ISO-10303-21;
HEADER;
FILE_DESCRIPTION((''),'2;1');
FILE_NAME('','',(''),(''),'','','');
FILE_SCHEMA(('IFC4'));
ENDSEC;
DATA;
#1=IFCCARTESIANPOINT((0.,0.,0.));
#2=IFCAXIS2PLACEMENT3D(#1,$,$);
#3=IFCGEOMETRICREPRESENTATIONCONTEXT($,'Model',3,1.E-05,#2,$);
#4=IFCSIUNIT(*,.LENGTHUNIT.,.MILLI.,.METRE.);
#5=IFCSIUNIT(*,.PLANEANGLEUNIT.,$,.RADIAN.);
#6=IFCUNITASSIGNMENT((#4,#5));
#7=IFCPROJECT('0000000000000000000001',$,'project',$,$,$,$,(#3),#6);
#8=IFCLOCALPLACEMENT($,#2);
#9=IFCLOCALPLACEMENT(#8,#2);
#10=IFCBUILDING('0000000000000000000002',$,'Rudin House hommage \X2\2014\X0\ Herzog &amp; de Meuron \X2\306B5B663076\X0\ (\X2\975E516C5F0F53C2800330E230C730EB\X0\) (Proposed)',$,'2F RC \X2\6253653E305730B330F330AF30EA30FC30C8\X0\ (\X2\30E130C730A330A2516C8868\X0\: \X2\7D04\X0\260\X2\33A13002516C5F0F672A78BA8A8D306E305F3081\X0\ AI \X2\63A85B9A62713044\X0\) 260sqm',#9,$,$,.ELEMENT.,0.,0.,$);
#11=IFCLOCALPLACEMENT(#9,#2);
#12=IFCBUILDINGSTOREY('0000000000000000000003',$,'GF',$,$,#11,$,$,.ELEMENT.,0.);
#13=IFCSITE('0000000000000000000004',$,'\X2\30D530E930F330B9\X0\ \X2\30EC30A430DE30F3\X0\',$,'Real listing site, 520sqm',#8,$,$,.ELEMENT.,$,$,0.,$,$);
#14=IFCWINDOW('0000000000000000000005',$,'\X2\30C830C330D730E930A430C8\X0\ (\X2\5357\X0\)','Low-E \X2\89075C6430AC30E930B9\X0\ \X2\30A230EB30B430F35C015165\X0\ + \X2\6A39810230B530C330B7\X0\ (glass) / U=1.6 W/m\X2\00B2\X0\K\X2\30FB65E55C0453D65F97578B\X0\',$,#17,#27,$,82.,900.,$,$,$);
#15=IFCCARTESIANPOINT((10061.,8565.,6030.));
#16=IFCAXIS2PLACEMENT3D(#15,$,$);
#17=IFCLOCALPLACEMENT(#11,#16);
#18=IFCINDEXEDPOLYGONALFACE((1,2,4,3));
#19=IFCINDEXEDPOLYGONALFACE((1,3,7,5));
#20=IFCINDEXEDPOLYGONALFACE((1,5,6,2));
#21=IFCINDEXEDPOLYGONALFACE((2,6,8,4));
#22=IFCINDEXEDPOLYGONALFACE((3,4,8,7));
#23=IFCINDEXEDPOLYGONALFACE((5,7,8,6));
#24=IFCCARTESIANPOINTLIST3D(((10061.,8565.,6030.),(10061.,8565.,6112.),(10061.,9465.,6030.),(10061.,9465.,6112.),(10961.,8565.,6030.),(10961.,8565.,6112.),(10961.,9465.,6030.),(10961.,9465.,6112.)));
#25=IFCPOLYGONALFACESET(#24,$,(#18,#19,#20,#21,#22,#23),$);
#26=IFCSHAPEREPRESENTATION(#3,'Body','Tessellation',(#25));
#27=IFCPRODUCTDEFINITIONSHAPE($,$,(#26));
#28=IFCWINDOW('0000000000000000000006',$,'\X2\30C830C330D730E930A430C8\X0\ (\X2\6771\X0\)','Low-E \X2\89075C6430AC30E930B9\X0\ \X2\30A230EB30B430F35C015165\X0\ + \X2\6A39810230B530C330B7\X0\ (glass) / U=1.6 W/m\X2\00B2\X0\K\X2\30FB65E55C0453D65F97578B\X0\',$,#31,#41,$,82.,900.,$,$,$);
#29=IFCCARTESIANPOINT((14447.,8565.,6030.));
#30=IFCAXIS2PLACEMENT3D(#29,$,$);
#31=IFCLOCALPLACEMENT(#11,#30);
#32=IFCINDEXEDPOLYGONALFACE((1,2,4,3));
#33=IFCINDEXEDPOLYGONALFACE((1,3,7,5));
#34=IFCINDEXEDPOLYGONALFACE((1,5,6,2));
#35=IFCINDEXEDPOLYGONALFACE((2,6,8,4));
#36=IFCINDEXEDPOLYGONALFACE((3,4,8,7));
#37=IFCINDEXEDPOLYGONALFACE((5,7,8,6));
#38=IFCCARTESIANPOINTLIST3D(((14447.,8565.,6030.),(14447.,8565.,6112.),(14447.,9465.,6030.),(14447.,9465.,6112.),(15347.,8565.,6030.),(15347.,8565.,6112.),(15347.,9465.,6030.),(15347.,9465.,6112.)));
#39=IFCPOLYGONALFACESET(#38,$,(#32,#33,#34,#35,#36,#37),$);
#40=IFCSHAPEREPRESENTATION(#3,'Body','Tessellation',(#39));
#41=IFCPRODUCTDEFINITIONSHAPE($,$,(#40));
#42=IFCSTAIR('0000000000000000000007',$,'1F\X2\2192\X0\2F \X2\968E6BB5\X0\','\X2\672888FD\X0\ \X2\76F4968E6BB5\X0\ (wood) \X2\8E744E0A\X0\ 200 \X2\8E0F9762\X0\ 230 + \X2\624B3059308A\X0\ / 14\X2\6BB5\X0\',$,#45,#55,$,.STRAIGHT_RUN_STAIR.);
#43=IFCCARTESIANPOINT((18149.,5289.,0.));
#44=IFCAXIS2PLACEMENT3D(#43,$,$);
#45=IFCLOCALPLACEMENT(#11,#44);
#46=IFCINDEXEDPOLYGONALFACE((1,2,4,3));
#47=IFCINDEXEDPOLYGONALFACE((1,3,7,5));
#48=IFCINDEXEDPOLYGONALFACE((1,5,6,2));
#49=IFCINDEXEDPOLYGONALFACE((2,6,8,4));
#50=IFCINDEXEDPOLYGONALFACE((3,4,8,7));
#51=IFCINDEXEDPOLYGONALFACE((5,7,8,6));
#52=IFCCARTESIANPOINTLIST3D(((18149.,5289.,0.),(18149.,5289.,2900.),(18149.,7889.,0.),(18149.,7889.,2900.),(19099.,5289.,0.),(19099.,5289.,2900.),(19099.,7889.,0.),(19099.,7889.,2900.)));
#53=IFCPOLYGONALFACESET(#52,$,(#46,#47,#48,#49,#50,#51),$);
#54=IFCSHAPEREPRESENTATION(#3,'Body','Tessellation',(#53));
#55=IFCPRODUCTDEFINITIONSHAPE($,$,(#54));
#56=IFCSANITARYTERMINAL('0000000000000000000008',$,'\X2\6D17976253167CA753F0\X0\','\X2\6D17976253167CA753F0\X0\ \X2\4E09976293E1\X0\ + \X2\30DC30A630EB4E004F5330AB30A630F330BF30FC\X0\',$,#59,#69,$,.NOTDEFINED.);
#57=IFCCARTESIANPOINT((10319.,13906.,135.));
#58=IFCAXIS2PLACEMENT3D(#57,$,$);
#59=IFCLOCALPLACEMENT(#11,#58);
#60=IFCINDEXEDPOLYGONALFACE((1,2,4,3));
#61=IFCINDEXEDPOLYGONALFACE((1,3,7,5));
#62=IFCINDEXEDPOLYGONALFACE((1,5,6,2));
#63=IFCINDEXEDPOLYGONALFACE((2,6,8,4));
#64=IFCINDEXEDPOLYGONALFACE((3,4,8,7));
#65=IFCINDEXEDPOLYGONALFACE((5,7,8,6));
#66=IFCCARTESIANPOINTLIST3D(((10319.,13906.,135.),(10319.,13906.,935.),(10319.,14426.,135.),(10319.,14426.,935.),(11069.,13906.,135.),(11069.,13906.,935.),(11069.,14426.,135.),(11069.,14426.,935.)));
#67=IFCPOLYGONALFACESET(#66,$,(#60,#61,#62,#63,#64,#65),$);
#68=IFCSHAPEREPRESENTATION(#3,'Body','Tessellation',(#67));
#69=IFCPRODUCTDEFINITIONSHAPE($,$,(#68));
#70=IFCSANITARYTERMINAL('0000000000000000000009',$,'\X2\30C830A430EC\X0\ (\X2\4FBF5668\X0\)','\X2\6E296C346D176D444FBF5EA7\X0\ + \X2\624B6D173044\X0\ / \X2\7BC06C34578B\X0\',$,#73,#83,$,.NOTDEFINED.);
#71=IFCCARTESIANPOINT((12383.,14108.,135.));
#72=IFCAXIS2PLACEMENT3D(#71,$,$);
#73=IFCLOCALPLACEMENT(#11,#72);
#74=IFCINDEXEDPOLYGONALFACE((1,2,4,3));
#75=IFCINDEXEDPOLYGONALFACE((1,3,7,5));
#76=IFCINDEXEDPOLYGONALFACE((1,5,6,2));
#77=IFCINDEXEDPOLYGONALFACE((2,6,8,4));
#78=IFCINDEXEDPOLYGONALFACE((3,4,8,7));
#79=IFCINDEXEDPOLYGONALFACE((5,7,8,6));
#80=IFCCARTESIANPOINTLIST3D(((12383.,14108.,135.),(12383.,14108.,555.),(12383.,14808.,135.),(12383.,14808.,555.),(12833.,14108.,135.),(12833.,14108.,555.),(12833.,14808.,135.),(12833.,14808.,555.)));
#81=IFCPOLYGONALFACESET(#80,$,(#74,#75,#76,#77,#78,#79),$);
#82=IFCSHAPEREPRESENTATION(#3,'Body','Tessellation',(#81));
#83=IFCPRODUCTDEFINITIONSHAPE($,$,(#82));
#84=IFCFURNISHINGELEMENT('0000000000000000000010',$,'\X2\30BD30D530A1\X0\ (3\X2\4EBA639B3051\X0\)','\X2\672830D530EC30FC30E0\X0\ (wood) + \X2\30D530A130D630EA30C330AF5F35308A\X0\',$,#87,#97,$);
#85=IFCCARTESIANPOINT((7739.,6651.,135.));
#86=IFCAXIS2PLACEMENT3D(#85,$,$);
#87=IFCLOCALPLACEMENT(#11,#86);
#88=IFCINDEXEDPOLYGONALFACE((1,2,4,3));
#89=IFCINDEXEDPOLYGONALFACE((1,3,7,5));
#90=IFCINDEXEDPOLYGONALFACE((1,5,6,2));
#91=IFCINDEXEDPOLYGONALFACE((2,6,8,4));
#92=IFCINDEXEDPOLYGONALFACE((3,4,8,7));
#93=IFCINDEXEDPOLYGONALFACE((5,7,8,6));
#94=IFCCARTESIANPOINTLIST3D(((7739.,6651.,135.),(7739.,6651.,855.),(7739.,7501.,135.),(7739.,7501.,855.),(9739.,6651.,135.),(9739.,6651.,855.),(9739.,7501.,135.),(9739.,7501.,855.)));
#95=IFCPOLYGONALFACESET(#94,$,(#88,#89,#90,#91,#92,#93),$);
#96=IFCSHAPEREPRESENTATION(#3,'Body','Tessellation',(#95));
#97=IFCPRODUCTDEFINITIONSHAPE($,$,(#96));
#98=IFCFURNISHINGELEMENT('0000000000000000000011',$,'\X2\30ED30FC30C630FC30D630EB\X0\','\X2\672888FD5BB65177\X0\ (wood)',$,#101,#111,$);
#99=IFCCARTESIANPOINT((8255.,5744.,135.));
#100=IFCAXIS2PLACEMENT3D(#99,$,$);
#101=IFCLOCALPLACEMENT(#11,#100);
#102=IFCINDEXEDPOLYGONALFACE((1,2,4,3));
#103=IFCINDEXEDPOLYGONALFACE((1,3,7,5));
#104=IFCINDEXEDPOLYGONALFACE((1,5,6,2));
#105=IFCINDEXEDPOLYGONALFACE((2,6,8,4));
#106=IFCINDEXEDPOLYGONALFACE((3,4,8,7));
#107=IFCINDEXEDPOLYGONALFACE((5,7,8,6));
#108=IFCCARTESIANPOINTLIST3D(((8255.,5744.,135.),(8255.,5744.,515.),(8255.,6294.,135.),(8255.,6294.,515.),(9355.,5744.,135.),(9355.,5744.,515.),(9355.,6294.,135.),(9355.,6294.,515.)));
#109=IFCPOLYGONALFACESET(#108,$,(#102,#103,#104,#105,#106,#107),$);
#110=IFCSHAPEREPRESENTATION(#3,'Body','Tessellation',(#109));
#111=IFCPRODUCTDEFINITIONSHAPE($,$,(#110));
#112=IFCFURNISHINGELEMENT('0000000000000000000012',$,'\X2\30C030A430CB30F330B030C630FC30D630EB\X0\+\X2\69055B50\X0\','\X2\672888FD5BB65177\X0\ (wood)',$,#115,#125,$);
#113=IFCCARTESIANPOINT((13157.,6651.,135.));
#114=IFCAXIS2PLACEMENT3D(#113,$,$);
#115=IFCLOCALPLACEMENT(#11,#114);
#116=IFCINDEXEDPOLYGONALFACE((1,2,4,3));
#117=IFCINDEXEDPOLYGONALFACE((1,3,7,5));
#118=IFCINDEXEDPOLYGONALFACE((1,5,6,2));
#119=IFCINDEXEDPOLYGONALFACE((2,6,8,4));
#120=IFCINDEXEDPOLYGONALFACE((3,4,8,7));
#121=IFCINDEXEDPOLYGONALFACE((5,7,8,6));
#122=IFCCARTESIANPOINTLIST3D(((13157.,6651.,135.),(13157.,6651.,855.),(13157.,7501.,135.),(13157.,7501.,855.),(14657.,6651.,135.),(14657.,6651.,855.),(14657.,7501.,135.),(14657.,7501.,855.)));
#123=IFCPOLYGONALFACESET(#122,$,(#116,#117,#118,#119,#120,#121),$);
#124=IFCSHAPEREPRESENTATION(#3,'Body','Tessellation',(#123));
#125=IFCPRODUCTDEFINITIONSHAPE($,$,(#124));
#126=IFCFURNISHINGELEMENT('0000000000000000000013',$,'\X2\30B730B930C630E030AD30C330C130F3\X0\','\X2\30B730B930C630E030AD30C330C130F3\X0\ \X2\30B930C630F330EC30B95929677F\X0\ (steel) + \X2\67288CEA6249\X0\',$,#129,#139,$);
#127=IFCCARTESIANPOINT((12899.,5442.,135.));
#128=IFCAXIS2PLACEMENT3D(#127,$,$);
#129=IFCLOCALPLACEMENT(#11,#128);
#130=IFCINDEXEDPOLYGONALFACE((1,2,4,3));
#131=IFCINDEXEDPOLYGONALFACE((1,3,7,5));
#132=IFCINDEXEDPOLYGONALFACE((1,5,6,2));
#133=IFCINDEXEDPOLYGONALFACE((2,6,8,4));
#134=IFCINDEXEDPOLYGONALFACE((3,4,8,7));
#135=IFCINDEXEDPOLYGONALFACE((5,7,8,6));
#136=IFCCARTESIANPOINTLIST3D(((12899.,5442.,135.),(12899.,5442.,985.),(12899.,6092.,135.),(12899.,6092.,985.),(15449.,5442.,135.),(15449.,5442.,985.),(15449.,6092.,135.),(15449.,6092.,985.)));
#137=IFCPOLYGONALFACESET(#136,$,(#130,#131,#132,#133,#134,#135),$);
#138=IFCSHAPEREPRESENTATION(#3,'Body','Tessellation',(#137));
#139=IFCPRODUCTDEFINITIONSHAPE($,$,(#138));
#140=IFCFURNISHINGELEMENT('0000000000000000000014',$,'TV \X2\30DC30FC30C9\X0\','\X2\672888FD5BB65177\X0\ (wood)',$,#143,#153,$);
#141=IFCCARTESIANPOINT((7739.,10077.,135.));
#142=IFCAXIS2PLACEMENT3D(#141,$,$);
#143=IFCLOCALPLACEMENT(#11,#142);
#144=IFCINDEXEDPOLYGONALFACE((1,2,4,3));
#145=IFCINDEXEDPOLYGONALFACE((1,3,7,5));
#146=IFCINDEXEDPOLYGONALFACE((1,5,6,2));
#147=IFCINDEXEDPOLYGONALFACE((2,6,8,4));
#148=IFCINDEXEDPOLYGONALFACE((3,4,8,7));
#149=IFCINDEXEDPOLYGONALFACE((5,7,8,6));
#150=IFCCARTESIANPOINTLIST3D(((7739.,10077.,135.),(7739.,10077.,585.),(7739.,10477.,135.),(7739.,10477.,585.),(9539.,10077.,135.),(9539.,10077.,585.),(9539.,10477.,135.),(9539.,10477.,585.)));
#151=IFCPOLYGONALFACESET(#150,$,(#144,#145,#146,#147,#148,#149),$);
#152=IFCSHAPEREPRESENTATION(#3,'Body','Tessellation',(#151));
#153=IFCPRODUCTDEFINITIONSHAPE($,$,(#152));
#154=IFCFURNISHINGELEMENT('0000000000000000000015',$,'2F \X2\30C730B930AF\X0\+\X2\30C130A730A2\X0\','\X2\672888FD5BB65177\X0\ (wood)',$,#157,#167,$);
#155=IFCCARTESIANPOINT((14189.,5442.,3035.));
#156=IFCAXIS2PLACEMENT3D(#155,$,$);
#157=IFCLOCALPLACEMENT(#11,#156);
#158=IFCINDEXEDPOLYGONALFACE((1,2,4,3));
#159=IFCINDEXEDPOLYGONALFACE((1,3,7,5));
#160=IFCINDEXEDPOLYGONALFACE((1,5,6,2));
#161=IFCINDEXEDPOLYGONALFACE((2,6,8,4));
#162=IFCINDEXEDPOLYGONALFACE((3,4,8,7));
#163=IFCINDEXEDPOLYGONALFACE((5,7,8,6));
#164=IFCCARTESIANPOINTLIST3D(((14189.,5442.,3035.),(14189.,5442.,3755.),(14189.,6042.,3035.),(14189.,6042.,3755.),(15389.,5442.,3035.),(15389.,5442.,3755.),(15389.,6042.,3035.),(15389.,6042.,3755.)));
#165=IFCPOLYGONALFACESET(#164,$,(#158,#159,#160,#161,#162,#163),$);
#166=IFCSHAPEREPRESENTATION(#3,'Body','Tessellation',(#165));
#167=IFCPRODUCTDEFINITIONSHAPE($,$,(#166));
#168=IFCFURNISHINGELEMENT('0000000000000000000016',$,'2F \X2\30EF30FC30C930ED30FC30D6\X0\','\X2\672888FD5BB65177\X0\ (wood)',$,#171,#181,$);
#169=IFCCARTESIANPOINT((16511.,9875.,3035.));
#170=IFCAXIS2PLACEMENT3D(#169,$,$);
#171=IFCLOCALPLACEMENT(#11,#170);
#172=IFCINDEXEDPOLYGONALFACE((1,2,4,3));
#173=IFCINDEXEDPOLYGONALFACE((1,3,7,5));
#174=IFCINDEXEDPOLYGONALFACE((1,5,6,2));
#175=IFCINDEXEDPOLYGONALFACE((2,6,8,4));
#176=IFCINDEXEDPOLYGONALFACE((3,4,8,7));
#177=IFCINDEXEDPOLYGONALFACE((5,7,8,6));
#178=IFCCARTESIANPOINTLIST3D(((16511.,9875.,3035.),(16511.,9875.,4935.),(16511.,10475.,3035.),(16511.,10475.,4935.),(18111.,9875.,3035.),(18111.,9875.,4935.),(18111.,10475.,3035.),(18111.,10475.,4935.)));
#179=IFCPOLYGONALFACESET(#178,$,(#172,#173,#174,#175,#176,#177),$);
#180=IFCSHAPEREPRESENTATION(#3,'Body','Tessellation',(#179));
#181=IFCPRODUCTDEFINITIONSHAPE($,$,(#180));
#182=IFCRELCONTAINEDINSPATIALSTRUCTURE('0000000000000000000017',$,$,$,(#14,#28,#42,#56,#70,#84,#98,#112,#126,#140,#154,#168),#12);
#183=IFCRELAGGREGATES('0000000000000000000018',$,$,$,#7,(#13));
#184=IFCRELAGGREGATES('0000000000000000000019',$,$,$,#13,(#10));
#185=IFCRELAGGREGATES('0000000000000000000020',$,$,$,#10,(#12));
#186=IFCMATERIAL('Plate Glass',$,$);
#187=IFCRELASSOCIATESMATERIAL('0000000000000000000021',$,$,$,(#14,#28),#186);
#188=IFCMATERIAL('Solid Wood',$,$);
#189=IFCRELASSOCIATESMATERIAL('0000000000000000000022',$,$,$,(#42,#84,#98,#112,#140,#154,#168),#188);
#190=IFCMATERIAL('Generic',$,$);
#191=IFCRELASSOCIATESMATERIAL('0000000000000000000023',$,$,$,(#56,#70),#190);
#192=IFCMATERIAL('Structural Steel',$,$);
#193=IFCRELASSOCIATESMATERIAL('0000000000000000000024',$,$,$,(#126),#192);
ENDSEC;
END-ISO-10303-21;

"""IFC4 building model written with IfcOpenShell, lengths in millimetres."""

from ifc_helpers import new_model, si_unit, frame, frame_2d, origin, place, context, project, spatial, rectangle, extrude, material, element, save


model = new_model("IFC4")

# Units and contexts
model_context = context("Model", 3, precision=1e-05, world=origin())
ifc_project = project(units=[si_unit("LENGTHUNIT", "METRE", prefix="MILLI"), si_unit("PLANEANGLEUNIT", "RADIAN")], contexts=[model_context])

# Site, building, storey
site_placement = place(None, origin())
site = spatial("IfcSite", under=ifc_project, at=site_placement, Name="フランス レイマン", ObjectType="Real listing site, 520sqm", CompositionType="ELEMENT", RefElevation=0.0)
building_placement = place(site_placement, origin())
building = spatial("IfcBuilding", under=site, at=building_placement, Name="Rudin House hommage — Herzog &amp; de Meuron に学ぶ (非公式参考モデル) (Proposed)", ObjectType="2F RC 打放しコンクリート (メディア公表: 約260㎡。公式未確認のため AI 推定扱い) 260sqm", CompositionType="ELEMENT", ElevationOfRefHeight=0.0, ElevationOfTerrain=0.0)
storey_placement = place(building_placement, origin())
storey = spatial("IfcBuildingStorey", under=building, at=storey_placement, Name="GF", CompositionType="ELEMENT", Elevation=0.0)

# Shared definitions
ifc_material_1 = material(Name="Solid Wood")

# Shared definitions
ifc_material_2 = material(Name="Plate Glass")

# Windows
window_1_placement = place(storey_placement, frame((10061.0, 8565.0, 6030.0)))
element("IfcWindow", 1, at=window_1_placement, inside=storey, material=ifc_material_2, Name="トップライト (南)", Description="Low-E 複層ガラス アルゴン封入 + 樹脂サッシ (glass) / U=1.6 W/m²K・日射取得型", OverallHeight=82.0, OverallWidth=900.0, context=model_context, shape_type="SweptSolid", body=[
    extrude(rectangle(XDim=900.0, YDim=900.0, at=frame_2d((450.0, 450.0))), frame((10061.0, 8565.0, 6030.0)), (0.0, 0.0, 1.0), 82.0),
])
window_2_placement = place(storey_placement, frame((14447.0, 8565.0, 6030.0)))
element("IfcWindow", 2, at=window_2_placement, inside=storey, material=ifc_material_2, Name="トップライト (東)", Description="Low-E 複層ガラス アルゴン封入 + 樹脂サッシ (glass) / U=1.6 W/m²K・日射取得型", OverallHeight=82.0, OverallWidth=900.0, context=model_context, shape_type="SweptSolid", body=[
    extrude(rectangle(XDim=900.0, YDim=900.0, at=frame_2d((450.0, 450.0))), frame((14447.0, 8565.0, 6030.0)), (0.0, 0.0, 1.0), 82.0),
])

# Stair
stair_placement = place(storey_placement, frame((18149.0, 5289.0, 0.0)))
element("IfcStair", 3, at=stair_placement, inside=storey, material=ifc_material_1, Name="1F→2F 階段", Description="木製 直階段 (wood) 蹴上 200 踏面 230 + 手すり / 14段", PredefinedType="STRAIGHT_RUN_STAIR", context=model_context, shape_type="SweptSolid", body=[
    extrude(rectangle(XDim=950.0, YDim=2600.0, at=frame_2d((475.0, 1300.0))), frame((18149.0, 5289.0, 0.0)), (0.0, 0.0, 1.0), 2900.0),
])

# Sanitary terminals
ifc_material_3 = material(Name="Generic")
sanitary_terminal_1_placement = place(storey_placement, frame((10319.0, 13906.0, 135.0)))
element("IfcSanitaryTerminal", 4, at=sanitary_terminal_1_placement, inside=storey, material=ifc_material_3, Name="洗面化粧台", Description="洗面化粧台 三面鏡 + ボウル一体カウンター", PredefinedType="NOTDEFINED", context=model_context, shape_type="SweptSolid", body=[
    extrude(rectangle(XDim=750.0, YDim=520.0, at=frame_2d((375.0, 260.0))), frame((10319.0, 13906.0, 135.0)), (0.0, 0.0, 1.0), 800.0),
])
sanitary_terminal_2_placement = place(storey_placement, frame((12383.0, 14108.0, 135.0)))
element("IfcSanitaryTerminal", 5, at=sanitary_terminal_2_placement, inside=storey, material=ifc_material_3, Name="トイレ (便器)", Description="温水洗浄便座 + 手洗い / 節水型", PredefinedType="NOTDEFINED", context=model_context, shape_type="SweptSolid", body=[
    extrude(rectangle(XDim=450.0, YDim=700.0, at=frame_2d((225.0, 350.0))), frame((12383.0, 14108.0, 135.0)), (0.0, 0.0, 1.0), 420.0),
])

# Furnishing elements
furnishing_1_placement = place(storey_placement, frame((7739.0, 6651.0, 135.0)))
element("IfcFurnishingElement", 6, at=furnishing_1_placement, inside=storey, material=ifc_material_1, Name="ソファ (3人掛け)", Description="木フレーム (wood) + ファブリック張り", context=model_context, shape_type="SweptSolid", body=[
    extrude(rectangle(XDim=2000.0, YDim=850.0, at=frame_2d((1000.0, 425.0))), frame((7739.0, 6651.0, 135.0)), (0.0, 0.0, 1.0), 720.0),
])
furnishing_2_placement = place(storey_placement, frame((8255.0, 5744.0, 135.0)))
element("IfcFurnishingElement", 7, at=furnishing_2_placement, inside=storey, material=ifc_material_1, Name="ローテーブル", Description="木製家具 (wood)", context=model_context, shape_type="SweptSolid", body=[
    extrude(rectangle(XDim=1100.0, YDim=550.0, at=frame_2d((550.0, 275.0))), frame((8255.0, 5744.0, 135.0)), (0.0, 0.0, 1.0), 380.0),
])
furnishing_3_placement = place(storey_placement, frame((13157.0, 6651.0, 135.0)))
element("IfcFurnishingElement", 8, at=furnishing_3_placement, inside=storey, material=ifc_material_1, Name="ダイニングテーブル+椅子", Description="木製家具 (wood)", context=model_context, shape_type="SweptSolid", body=[
    extrude(rectangle(XDim=1500.0, YDim=850.0, at=frame_2d((750.0, 425.0))), frame((13157.0, 6651.0, 135.0)), (0.0, 0.0, 1.0), 720.0),
])
ifc_material_4 = material(Name="Structural Steel")
furnishing_4_placement = place(storey_placement, frame((12899.0, 5442.0, 135.0)))
element("IfcFurnishingElement", 9, at=furnishing_4_placement, inside=storey, material=ifc_material_4, Name="システムキッチン", Description="システムキッチン ステンレス天板 (steel) + 木質扉", context=model_context, shape_type="SweptSolid", body=[
    extrude(rectangle(XDim=2550.0, YDim=650.0, at=frame_2d((1275.0, 325.0))), frame((12899.0, 5442.0, 135.0)), (0.0, 0.0, 1.0), 850.0),
])
furnishing_5_placement = place(storey_placement, frame((7739.0, 10077.0, 135.0)))
element("IfcFurnishingElement", 10, at=furnishing_5_placement, inside=storey, material=ifc_material_1, Name="TV ボード", Description="木製家具 (wood)", context=model_context, shape_type="SweptSolid", body=[
    extrude(rectangle(XDim=1800.0, YDim=400.0, at=frame_2d((900.0, 200.0))), frame((7739.0, 10077.0, 135.0)), (0.0, 0.0, 1.0), 450.0),
])
furnishing_6_placement = place(storey_placement, frame((14189.0, 5442.0, 3035.0)))
element("IfcFurnishingElement", 11, at=furnishing_6_placement, inside=storey, material=ifc_material_1, Name="2F デスク+チェア", Description="木製家具 (wood)", context=model_context, shape_type="SweptSolid", body=[
    extrude(rectangle(XDim=1200.0, YDim=600.0, at=frame_2d((600.0, 300.0))), frame((14189.0, 5442.0, 3035.0)), (0.0, 0.0, 1.0), 720.0),
])
furnishing_7_placement = place(storey_placement, frame((16511.0, 9875.0, 3035.0)))
element("IfcFurnishingElement", 12, at=furnishing_7_placement, inside=storey, material=ifc_material_1, Name="2F ワードローブ", Description="木製家具 (wood)", context=model_context, shape_type="SweptSolid", body=[
    extrude(rectangle(XDim=1600.0, YDim=600.0, at=frame_2d((800.0, 300.0))), frame((16511.0, 9875.0, 3035.0)), (0.0, 0.0, 1.0), 1900.0),
])

save(model, "model.ifc")
